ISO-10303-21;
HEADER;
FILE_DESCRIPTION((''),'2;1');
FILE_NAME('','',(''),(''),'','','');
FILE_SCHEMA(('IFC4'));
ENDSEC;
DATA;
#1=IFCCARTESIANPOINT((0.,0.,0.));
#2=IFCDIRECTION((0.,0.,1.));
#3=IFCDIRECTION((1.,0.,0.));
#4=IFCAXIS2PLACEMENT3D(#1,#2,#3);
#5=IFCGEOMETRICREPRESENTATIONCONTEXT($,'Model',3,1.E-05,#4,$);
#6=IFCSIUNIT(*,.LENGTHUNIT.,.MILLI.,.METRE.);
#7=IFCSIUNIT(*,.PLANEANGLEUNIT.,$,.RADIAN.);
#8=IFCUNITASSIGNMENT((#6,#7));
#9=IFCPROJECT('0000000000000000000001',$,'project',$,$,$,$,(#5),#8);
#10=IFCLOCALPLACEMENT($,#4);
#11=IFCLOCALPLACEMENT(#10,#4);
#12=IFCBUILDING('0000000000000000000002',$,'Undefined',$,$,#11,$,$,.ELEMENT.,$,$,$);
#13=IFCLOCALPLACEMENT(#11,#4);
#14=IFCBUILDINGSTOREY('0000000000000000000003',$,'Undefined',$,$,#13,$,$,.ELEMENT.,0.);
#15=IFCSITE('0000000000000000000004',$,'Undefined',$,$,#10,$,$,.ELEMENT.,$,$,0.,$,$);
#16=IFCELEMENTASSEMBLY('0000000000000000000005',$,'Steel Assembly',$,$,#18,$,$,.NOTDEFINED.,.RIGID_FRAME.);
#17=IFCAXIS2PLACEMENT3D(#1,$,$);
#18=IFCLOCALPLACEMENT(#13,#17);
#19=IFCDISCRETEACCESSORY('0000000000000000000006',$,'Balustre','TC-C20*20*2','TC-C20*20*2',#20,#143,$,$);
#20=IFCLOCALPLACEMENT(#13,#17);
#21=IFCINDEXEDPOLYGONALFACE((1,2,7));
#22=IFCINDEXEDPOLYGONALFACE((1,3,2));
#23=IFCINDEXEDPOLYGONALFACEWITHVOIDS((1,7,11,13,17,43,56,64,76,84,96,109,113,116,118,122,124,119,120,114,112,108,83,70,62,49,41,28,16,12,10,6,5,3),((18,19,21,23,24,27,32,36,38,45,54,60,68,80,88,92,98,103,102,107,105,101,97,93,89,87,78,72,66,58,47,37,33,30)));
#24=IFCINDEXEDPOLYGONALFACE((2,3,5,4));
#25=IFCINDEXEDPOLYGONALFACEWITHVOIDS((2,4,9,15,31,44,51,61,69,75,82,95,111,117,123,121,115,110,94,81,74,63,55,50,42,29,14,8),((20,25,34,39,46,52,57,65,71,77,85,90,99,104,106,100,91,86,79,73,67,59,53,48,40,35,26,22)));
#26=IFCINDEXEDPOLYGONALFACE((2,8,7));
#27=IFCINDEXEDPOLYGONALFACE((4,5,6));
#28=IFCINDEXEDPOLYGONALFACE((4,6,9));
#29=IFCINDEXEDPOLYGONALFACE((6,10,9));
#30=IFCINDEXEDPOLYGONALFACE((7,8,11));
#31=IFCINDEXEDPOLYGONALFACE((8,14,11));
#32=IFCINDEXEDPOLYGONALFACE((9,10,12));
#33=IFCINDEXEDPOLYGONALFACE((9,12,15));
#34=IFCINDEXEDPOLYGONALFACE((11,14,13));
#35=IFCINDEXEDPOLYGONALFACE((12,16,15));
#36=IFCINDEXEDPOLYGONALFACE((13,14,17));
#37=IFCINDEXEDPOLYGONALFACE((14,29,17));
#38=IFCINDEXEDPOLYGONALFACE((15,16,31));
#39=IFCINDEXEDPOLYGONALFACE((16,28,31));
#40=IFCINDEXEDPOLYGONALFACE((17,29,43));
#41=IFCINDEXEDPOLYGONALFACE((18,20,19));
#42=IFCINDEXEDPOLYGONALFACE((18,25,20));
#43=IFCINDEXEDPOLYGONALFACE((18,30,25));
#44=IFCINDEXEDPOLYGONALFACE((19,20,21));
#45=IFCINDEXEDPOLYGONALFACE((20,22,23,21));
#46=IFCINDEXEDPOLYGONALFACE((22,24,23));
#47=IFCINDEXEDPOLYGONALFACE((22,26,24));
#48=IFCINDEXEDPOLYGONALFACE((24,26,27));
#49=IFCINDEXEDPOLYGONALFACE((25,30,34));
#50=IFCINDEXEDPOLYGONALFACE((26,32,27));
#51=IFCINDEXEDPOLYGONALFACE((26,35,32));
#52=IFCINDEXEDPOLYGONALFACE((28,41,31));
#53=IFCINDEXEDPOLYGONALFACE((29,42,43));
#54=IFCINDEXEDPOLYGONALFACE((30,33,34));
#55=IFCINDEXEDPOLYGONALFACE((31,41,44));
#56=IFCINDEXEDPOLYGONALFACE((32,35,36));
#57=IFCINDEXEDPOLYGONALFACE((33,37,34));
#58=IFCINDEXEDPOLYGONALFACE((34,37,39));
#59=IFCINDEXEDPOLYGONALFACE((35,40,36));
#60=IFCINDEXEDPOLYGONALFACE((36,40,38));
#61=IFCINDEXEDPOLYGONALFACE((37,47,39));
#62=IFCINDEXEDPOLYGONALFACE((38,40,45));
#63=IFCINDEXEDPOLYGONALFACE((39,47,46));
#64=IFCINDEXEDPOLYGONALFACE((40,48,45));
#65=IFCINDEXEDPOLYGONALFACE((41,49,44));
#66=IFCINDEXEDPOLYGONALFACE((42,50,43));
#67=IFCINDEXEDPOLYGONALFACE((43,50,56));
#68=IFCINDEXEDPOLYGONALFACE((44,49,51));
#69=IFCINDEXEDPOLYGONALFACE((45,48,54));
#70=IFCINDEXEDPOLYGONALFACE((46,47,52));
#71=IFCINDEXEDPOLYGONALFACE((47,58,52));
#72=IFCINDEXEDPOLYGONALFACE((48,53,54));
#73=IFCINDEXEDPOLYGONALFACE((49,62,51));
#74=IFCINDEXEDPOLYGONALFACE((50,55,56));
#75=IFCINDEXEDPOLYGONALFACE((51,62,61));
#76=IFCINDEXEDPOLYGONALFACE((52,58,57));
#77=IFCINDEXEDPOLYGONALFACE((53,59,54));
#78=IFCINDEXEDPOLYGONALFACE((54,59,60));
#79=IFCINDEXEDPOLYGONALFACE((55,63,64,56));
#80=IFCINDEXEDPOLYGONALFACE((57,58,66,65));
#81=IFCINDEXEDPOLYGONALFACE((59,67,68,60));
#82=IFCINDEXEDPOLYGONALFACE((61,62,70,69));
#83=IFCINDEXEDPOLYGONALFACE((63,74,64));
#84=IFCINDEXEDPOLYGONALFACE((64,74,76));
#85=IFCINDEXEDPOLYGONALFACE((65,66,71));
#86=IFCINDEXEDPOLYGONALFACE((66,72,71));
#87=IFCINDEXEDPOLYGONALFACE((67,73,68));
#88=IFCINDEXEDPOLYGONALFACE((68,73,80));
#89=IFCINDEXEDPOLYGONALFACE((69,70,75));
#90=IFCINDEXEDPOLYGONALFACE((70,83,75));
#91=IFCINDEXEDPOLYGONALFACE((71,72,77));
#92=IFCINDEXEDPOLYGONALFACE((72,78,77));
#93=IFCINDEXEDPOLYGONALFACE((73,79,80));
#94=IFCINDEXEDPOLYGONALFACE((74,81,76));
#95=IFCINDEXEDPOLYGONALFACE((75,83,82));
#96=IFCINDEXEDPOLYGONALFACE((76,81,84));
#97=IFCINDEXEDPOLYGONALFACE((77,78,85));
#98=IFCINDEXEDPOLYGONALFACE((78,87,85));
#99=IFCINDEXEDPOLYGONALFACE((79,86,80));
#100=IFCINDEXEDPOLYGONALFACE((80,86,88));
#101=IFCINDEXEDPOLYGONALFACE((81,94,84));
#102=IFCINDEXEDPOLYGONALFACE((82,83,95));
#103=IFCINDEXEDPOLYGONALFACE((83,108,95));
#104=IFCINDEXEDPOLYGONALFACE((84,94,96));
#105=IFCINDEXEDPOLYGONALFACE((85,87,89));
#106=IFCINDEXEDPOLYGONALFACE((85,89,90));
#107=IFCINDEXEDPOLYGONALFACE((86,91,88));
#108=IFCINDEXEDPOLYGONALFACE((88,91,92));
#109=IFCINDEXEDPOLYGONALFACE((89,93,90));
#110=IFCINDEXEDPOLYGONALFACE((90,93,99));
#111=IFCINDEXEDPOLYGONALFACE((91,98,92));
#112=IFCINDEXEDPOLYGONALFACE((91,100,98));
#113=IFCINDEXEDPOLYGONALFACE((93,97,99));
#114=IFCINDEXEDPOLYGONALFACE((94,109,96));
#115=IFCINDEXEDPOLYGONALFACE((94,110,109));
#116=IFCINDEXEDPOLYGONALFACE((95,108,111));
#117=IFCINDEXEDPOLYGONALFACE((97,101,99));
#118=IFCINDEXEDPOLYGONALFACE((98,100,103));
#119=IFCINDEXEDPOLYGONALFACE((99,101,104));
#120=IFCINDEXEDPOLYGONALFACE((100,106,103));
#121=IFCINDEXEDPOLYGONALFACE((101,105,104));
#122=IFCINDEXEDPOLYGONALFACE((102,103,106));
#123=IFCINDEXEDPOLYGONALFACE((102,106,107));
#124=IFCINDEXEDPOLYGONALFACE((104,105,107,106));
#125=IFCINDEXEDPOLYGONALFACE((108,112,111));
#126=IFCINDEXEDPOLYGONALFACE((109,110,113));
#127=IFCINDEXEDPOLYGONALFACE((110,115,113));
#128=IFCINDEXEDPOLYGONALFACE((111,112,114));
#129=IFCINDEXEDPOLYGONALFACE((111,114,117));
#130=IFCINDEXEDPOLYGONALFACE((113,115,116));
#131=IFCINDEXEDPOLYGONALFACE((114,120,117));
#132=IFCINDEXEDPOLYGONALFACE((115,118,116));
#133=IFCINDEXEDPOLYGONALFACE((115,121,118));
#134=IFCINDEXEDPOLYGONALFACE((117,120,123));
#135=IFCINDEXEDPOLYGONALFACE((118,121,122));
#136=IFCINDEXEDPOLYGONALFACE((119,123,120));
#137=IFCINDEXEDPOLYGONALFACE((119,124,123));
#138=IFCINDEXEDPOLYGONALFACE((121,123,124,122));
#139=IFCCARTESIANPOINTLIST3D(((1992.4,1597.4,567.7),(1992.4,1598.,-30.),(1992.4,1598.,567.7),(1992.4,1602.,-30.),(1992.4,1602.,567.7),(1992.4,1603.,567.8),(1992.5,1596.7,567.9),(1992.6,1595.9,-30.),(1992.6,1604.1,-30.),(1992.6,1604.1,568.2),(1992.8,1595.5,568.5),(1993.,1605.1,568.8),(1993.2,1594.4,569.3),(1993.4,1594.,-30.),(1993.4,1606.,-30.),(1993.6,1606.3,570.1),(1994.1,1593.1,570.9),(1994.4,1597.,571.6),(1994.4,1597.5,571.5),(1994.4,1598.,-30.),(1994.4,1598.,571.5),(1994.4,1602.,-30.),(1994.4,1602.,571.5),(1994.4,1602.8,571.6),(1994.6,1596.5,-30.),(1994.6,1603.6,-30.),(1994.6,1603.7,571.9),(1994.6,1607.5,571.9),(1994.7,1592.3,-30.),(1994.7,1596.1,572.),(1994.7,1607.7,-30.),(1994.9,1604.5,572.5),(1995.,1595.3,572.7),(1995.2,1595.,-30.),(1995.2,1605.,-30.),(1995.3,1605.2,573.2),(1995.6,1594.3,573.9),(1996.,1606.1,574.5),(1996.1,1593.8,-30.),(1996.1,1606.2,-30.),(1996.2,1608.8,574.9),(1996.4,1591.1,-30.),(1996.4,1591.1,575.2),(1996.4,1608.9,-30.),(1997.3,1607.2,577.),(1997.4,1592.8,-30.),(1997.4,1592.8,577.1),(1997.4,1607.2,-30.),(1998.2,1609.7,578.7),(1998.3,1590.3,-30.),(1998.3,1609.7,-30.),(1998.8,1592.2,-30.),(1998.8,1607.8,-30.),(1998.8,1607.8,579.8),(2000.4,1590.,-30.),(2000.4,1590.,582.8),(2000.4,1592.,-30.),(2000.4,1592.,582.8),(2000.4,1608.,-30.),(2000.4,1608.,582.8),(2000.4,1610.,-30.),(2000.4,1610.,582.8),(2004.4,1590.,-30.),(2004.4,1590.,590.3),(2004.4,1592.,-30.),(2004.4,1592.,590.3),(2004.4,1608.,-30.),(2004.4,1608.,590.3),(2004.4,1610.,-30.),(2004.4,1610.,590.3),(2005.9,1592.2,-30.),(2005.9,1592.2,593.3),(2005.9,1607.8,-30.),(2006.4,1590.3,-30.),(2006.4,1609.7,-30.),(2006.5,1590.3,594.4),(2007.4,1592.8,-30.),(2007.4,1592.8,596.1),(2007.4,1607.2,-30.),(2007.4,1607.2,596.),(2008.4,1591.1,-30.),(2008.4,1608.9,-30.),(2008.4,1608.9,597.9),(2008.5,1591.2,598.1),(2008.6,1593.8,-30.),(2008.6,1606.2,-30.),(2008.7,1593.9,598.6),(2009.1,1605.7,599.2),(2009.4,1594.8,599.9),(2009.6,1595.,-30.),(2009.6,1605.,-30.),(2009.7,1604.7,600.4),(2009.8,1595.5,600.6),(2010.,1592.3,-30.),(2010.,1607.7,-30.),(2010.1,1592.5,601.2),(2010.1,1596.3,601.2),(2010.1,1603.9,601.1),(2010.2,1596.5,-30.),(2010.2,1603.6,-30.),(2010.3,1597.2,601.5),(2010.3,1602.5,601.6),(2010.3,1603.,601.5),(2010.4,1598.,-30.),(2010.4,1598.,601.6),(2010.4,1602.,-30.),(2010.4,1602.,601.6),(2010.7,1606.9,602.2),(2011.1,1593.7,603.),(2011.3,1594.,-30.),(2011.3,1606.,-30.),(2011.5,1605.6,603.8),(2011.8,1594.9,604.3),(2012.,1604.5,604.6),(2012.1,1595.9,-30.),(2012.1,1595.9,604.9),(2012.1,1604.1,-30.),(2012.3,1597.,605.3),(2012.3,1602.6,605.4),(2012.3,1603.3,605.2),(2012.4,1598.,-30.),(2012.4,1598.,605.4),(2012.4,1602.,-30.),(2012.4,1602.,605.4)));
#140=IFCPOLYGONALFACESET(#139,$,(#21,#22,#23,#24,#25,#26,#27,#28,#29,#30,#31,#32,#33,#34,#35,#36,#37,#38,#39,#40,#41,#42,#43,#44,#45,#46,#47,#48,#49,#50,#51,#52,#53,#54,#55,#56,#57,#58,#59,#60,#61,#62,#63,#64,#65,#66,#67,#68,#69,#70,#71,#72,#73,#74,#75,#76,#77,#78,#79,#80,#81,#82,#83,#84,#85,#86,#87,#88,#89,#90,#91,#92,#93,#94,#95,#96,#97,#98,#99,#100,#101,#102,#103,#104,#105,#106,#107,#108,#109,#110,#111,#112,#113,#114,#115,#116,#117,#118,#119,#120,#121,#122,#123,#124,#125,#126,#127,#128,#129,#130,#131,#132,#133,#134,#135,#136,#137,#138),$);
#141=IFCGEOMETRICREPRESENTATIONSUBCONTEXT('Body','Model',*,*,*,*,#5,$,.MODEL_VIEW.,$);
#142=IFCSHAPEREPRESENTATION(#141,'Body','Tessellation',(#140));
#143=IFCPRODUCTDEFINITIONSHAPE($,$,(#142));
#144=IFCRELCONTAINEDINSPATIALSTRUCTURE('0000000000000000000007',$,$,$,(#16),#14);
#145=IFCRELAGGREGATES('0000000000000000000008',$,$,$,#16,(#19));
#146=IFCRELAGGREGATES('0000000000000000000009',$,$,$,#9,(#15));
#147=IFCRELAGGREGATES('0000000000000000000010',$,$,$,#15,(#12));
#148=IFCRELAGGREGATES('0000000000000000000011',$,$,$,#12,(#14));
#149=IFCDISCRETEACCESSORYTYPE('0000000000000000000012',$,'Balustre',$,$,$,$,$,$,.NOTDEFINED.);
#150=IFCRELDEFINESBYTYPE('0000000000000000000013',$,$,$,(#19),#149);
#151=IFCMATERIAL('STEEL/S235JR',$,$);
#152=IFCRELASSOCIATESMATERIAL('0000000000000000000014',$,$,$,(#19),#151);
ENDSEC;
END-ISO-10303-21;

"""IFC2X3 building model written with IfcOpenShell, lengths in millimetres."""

from ifc_helpers import new_model, si_unit, frame, origin_with_axes, origin_2d_with_axis, place, context, subcontext, project, spatial, hollow_rectangle, extrude, clip, halfspace, material, type_object, element, aggregate, save


model = new_model("IFC2X3")

# Units and contexts
model_context = context("Model", 3, precision=1e-05, world=origin_with_axes())
body_context = subcontext(model_context, "Body", "Model", "MODEL_VIEW")
ifc_project = project(units=[si_unit("LENGTHUNIT", "METRE", prefix="MILLI"), si_unit("PLANEANGLEUNIT", "RADIAN")], contexts=[model_context])

# Site, building, storey
site_placement = place(None, origin_with_axes())
site = spatial("IfcSite", under=ifc_project, at=site_placement, Name="Undefined", CompositionType="ELEMENT", RefElevation=0.0)
building_placement = place(site_placement, origin_with_axes())
building = spatial("IfcBuilding", under=site, at=building_placement, Name="Undefined", CompositionType="ELEMENT")
storey_placement = place(building_placement, origin_with_axes())
storey = spatial("IfcBuildingStorey", under=building, at=storey_placement, Name="Undefined", CompositionType="ELEMENT", Elevation=0.0)

# Element assembly
assembly_1_placement = place(storey_placement, origin_with_axes())
assembly_1 = element("IfcElementAssembly", 1, at=assembly_1_placement, inside=storey, Name="Steel Assembly", AssemblyPlace="NOTDEFINED", PredefinedType="RIGID_FRAME")
ifc_material = material(Name="STEEL/S235JR")

# Discrete accessory
discrete_accessory_type_1 = type_object("IfcDiscreteAccessoryType", Name="Balustre")
discrete_accessory_1_placement = place(assembly_1_placement, frame((2002.4, 1600.0, -30.0), z_axis=(0.0, 0.0, 1.0), x_axis=(1.0, 0.0, 0.0)))
discrete_accessory_1 = element("IfcDiscreteAccessory", 2, at=discrete_accessory_1_placement, type_object=discrete_accessory_type_1, material=ifc_material, Name="Balustre", Description="TC-C20*20*2", ObjectType="TC-C20*20*2", context=body_context, shape_type="Clipping", body=[
    clip(extrude(hollow_rectangle(XDim=20.0, YDim=20.0, WallThickness=2.0, InnerFilletRadius=6.0, OuterFilletRadius=8.0, at=origin_2d_with_axis()), frame((0.0, 0.0, 635.6), z_axis=(0.0, 0.0, -1.0), x_axis=(-1.0, 0.0, 0.0)), (0.0, 0.0, 1.0), 635.6), halfspace(frame((12.4, 0.0, 640.0), z_axis=(0.883506, 0.000005, -0.46842), x_axis=(-0.000005, 1.0, 0.0)), True)),
])
aggregate(assembly_1, [discrete_accessory_1])

save(model, "model.ifc")
